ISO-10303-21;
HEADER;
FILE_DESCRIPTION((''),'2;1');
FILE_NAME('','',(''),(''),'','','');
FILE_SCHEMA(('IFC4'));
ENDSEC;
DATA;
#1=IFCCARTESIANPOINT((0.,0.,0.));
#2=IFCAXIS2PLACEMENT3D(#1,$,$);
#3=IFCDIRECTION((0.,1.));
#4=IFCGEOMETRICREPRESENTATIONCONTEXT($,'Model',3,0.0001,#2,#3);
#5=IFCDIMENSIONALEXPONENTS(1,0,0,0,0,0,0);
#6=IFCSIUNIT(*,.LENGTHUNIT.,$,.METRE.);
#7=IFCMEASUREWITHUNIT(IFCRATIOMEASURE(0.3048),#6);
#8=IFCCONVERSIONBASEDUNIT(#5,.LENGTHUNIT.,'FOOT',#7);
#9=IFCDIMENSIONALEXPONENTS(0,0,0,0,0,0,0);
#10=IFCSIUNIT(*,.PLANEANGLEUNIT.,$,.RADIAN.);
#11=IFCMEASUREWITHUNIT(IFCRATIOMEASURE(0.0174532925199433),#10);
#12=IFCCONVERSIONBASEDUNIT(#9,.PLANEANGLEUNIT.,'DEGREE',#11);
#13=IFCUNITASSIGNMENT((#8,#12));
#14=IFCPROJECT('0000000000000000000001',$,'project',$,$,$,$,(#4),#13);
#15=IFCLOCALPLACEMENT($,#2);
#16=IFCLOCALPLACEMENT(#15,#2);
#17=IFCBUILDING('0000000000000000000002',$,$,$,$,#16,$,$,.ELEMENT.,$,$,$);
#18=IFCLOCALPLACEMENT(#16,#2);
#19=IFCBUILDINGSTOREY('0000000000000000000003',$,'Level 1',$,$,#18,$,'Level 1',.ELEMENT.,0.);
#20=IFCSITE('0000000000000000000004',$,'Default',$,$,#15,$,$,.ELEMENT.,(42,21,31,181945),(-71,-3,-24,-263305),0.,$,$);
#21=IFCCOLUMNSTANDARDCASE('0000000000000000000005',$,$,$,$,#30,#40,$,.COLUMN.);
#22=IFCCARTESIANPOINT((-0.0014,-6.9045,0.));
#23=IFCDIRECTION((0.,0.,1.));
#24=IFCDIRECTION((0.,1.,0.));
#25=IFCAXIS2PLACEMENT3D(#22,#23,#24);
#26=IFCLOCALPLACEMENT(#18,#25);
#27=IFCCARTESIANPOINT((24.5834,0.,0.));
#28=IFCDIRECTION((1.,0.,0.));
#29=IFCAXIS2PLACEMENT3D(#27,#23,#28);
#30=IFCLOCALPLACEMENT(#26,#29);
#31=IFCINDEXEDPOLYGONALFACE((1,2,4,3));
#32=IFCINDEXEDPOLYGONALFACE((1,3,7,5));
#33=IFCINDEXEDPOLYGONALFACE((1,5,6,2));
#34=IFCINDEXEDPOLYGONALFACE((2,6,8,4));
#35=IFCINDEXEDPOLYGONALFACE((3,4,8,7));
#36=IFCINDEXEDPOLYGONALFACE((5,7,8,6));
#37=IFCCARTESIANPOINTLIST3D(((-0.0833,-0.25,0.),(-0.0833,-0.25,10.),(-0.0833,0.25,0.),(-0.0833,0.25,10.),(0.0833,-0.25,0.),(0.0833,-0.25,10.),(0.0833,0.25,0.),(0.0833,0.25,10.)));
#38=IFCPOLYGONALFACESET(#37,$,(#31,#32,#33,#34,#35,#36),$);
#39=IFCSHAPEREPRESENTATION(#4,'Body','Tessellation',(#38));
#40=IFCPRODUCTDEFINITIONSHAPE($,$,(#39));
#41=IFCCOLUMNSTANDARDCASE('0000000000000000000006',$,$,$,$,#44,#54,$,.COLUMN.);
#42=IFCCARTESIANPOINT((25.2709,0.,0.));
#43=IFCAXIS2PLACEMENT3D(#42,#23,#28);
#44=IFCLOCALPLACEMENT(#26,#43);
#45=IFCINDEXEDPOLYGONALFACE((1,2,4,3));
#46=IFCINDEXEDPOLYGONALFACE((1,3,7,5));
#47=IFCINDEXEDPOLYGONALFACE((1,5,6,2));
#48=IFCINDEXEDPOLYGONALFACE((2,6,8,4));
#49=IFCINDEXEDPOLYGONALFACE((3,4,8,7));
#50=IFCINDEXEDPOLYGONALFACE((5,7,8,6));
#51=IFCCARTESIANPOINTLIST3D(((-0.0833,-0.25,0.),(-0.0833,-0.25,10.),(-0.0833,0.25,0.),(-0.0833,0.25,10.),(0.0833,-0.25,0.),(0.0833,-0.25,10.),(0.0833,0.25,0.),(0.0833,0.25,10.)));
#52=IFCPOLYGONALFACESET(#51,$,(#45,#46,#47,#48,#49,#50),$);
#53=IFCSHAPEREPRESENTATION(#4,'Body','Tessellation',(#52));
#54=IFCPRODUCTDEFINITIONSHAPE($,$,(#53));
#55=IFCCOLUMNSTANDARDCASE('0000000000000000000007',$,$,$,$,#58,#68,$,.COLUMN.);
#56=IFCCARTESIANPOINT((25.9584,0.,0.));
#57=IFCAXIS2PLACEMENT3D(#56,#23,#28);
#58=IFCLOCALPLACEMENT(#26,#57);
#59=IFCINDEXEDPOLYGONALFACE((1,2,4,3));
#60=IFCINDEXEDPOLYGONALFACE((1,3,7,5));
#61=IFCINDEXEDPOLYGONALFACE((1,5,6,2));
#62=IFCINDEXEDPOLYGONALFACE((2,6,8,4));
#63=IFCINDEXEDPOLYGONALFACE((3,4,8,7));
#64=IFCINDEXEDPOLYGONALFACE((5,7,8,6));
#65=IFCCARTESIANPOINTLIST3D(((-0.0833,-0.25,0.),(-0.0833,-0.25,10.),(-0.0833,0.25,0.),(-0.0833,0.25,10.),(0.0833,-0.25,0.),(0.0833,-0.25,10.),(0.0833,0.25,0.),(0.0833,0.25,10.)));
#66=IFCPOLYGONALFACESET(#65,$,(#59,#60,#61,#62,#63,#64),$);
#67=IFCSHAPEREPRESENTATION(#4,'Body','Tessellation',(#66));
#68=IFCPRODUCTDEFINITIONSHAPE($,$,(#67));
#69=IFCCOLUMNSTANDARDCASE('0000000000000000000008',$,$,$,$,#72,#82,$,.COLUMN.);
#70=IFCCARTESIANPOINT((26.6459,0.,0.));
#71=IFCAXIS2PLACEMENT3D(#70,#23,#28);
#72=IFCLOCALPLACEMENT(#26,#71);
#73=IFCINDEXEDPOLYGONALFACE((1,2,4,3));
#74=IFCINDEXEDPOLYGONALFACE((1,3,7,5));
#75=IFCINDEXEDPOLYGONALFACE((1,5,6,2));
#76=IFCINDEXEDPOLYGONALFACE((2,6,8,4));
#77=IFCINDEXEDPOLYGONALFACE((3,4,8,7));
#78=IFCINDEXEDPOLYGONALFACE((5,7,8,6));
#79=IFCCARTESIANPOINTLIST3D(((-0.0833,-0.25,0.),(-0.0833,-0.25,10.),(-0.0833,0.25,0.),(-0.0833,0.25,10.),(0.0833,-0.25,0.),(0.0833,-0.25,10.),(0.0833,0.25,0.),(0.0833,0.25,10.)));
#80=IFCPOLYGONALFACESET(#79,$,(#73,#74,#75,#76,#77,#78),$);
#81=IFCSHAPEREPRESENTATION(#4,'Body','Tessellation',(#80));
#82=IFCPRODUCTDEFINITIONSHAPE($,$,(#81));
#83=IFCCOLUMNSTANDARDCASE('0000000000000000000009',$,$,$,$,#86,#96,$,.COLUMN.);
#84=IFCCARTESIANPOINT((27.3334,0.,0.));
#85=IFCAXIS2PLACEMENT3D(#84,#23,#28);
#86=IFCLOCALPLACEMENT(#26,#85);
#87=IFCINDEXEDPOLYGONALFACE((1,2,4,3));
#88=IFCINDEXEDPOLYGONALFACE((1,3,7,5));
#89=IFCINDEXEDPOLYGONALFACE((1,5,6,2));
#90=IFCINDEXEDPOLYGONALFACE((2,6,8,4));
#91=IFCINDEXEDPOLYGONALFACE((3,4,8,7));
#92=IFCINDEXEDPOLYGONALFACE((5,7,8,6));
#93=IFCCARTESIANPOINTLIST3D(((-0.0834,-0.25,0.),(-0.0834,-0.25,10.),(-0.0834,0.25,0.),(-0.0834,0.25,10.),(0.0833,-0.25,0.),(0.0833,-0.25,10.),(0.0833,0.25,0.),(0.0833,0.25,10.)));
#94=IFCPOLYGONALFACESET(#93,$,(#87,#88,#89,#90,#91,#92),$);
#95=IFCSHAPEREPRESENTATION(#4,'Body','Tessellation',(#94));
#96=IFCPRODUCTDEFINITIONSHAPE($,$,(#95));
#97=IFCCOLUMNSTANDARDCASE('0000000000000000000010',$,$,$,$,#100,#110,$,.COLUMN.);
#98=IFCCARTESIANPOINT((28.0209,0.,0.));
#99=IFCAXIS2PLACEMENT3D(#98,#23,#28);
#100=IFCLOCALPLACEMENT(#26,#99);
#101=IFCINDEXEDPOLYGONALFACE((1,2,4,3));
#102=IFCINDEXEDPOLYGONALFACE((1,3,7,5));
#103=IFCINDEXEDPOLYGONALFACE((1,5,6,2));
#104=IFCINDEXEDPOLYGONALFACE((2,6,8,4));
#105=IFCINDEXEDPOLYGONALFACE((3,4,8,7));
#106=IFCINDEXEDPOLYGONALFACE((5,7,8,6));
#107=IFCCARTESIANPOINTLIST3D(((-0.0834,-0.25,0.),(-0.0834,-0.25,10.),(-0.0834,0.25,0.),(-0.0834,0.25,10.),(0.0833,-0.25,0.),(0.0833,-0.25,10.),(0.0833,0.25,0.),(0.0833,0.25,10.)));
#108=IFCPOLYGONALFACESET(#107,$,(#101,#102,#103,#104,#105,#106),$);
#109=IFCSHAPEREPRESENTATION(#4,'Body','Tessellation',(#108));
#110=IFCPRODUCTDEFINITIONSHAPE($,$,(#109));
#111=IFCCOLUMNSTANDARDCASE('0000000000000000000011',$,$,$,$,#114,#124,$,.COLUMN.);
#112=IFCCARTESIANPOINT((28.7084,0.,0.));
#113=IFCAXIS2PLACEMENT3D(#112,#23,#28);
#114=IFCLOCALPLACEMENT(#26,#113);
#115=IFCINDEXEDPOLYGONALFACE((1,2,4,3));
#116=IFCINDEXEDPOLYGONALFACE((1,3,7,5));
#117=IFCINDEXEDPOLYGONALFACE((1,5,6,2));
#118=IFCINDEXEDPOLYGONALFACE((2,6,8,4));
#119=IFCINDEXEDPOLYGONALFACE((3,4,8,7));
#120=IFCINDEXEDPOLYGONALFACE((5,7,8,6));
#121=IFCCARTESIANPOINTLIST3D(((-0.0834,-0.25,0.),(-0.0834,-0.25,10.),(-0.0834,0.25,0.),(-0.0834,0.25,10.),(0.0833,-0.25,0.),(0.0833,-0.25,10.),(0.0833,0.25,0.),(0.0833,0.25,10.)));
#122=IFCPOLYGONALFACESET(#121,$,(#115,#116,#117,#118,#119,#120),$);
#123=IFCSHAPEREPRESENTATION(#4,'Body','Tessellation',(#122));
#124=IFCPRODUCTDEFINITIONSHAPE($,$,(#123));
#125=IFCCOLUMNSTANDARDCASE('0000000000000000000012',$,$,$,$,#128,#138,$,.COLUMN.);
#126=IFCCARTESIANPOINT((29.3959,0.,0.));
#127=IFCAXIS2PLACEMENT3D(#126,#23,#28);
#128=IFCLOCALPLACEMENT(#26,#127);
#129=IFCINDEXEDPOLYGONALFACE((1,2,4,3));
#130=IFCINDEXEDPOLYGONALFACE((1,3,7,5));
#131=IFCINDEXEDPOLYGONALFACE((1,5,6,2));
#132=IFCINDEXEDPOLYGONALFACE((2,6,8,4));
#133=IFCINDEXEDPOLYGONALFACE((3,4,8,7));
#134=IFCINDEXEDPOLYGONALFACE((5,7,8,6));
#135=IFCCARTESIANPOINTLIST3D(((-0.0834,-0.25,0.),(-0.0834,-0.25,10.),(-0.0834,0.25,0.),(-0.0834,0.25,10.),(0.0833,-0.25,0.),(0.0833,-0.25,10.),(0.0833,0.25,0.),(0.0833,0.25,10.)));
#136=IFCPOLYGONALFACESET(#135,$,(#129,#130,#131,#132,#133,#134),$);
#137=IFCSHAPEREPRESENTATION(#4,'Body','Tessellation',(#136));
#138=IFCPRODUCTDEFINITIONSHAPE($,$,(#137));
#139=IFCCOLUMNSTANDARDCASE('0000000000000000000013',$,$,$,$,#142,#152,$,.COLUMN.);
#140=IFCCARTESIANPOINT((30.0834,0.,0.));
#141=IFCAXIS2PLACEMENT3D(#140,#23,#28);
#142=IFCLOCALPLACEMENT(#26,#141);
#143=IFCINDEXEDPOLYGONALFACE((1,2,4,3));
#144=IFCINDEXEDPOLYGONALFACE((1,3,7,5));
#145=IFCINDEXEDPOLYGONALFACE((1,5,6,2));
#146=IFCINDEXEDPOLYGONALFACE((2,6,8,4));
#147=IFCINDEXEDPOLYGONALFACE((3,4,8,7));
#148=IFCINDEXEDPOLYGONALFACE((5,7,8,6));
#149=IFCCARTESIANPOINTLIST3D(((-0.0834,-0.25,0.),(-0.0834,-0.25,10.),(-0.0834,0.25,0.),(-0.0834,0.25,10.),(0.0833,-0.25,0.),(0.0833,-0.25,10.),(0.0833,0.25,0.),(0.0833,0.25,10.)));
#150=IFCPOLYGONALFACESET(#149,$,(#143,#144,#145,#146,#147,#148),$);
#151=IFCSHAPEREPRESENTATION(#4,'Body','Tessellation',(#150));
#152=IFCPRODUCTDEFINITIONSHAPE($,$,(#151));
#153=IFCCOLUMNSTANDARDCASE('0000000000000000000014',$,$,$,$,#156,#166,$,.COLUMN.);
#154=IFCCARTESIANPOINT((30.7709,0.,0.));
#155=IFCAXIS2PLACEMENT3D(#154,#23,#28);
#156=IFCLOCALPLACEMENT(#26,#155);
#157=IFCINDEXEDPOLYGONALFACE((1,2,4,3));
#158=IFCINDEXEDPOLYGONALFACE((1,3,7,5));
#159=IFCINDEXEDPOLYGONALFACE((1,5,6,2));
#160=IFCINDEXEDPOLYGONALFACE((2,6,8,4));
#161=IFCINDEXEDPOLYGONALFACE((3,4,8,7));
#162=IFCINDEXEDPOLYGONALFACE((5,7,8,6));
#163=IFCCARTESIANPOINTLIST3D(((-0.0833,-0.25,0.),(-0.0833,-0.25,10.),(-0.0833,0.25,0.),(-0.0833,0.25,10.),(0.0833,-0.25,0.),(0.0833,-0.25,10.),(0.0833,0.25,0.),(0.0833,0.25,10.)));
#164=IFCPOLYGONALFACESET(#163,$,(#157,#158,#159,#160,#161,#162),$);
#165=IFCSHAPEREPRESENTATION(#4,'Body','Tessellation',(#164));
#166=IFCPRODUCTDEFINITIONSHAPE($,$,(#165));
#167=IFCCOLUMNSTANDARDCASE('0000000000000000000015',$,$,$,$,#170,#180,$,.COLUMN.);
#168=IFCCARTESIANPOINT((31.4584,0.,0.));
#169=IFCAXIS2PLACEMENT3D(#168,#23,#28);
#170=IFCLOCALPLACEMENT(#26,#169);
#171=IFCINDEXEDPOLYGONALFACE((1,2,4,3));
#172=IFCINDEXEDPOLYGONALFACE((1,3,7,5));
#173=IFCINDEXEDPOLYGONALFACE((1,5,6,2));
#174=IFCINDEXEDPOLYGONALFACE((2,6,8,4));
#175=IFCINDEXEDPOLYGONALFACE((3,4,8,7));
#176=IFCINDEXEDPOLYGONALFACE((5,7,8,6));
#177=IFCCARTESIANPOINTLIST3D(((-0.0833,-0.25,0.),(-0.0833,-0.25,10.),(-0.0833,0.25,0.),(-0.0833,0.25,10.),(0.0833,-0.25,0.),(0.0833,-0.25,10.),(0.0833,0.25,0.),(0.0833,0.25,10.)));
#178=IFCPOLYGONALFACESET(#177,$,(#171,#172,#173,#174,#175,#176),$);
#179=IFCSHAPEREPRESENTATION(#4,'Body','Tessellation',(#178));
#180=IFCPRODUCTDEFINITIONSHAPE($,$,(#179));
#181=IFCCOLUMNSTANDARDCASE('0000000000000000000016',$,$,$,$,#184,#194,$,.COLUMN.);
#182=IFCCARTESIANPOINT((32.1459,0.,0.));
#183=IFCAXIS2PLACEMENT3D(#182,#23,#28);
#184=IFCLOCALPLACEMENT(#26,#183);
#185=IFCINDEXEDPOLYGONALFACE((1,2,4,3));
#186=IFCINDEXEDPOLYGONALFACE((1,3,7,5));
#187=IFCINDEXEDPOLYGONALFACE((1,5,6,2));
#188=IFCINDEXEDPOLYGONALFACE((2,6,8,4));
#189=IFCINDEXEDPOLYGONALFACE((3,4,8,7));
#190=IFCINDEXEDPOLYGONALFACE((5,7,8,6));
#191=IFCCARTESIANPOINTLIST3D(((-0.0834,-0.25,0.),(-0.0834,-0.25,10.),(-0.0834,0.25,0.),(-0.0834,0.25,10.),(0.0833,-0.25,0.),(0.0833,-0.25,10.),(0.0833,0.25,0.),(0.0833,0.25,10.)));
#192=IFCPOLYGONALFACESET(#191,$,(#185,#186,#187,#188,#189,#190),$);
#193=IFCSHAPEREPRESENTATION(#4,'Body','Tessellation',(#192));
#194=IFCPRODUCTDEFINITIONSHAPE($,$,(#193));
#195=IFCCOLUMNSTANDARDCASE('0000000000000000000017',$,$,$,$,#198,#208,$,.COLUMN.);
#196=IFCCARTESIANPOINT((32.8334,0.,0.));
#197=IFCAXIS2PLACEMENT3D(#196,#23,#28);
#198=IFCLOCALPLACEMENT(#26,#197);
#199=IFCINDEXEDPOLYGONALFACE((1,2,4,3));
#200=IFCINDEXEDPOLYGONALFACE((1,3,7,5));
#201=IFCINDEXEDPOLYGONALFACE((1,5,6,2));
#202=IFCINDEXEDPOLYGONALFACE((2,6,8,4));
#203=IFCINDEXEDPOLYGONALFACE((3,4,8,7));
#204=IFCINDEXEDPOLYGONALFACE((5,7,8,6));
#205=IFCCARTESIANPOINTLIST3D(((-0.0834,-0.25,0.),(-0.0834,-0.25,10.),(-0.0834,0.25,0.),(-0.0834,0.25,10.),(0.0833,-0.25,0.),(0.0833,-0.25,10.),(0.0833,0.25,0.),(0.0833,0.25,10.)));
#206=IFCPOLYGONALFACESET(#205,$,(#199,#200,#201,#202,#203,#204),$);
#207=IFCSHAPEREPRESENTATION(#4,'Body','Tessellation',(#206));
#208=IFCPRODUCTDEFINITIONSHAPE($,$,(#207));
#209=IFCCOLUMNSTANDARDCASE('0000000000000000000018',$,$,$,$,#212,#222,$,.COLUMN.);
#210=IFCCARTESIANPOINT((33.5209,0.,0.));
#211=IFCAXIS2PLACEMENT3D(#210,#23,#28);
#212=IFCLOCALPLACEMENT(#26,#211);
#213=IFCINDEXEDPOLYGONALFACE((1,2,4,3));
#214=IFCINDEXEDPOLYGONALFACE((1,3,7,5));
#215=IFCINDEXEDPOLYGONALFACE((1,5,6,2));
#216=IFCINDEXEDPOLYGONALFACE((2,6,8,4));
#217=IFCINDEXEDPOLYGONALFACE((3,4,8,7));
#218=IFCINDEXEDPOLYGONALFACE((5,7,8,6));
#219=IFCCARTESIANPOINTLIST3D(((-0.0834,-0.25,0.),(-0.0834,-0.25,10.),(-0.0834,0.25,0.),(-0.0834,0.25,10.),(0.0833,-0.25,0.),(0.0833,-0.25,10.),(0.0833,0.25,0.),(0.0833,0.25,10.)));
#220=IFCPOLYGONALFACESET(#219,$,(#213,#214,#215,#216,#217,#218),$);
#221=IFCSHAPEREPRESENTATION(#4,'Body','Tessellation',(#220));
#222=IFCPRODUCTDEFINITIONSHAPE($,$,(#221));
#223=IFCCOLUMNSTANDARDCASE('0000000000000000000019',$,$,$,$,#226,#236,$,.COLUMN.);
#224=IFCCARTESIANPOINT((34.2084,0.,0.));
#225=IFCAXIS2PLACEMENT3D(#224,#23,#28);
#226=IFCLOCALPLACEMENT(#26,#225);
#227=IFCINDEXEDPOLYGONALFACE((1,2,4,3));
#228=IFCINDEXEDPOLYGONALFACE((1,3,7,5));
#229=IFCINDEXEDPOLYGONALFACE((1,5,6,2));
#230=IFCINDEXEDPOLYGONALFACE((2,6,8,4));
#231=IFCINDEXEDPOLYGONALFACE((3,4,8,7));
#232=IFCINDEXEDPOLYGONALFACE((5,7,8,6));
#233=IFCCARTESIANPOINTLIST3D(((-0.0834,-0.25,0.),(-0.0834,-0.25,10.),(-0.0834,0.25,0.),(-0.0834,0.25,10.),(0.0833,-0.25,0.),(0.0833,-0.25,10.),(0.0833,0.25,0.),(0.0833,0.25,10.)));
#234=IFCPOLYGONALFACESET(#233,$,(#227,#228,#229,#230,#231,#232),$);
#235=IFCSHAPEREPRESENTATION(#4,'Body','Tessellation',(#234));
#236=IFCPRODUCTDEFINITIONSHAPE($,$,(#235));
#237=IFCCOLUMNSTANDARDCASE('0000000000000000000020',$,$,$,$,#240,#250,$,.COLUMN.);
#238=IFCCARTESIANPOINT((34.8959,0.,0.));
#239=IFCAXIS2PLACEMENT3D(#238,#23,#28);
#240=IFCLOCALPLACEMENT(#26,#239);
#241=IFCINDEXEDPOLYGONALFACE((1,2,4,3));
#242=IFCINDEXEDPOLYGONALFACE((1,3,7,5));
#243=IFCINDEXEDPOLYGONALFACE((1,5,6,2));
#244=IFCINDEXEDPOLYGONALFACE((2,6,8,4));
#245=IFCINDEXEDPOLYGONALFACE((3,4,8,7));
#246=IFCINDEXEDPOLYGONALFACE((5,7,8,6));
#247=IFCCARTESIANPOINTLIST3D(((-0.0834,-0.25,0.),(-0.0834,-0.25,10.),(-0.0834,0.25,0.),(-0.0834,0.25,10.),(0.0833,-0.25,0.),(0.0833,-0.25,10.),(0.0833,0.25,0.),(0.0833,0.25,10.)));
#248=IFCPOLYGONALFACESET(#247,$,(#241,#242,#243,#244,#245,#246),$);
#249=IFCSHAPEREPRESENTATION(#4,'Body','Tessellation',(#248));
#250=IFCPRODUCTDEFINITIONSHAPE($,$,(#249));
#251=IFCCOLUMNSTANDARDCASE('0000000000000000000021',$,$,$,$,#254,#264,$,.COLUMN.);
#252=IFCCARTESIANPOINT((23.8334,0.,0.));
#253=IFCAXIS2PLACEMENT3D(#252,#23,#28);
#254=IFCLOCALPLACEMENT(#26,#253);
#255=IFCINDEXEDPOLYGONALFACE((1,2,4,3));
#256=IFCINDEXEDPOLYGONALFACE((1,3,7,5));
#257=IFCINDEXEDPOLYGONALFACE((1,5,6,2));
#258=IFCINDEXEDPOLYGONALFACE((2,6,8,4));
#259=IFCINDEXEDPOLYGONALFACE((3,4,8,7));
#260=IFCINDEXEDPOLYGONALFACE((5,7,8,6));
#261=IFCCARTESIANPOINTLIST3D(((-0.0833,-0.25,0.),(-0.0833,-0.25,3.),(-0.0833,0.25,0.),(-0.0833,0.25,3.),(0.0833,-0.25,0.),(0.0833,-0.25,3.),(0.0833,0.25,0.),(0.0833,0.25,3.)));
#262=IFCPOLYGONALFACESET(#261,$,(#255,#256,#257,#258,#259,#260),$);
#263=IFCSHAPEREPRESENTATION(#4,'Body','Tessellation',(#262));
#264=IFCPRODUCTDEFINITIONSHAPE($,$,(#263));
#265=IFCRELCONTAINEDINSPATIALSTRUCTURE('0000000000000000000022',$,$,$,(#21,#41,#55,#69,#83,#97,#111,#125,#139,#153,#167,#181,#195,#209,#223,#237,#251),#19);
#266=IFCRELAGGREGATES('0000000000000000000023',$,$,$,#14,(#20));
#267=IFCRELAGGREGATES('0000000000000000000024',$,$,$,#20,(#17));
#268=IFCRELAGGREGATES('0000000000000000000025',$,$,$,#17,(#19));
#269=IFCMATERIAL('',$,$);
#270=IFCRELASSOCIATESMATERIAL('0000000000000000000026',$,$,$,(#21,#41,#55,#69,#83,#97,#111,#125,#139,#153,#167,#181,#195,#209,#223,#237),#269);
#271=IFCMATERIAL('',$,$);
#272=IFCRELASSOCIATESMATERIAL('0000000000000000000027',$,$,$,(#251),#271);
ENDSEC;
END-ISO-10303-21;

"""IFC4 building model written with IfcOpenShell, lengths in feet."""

from ifc_helpers import new_model, entity, si_unit, converted_unit, direction, frame, origin, place, context, project, spatial, rectangle, extrude, material, element, save


model = new_model("IFC4")

# Units and contexts
model_context = context("Model", 3, precision=0.0001, world=origin(), true_north=direction((0.0, 1.0)))
ifc_project = project(units=[converted_unit("LENGTHUNIT", "FOOT", entity("IfcRatioMeasure", 0.3048), si_unit("LENGTHUNIT", "METRE"), dimensions=[1, 0, 0, 0, 0, 0, 0]), converted_unit("PLANEANGLEUNIT", "DEGREE", entity("IfcRatioMeasure", 0.0174532925199433), si_unit("PLANEANGLEUNIT", "RADIAN"), dimensions=[0, 0, 0, 0, 0, 0, 0])], contexts=[model_context])

# Site, building, storey
site_placement = place(None, origin())
site = spatial("IfcSite", under=ifc_project, at=site_placement, Name="Default", CompositionType="ELEMENT", RefLatitude=(42, 21, 31, 181945), RefLongitude=(-71, -3, -24, -263305), RefElevation=0.0)
building_placement = place(site_placement, origin())
building = spatial("IfcBuilding", under=site, at=building_placement, CompositionType="ELEMENT")
storey_placement = place(building_placement, origin())
storey = spatial("IfcBuildingStorey", under=building, at=storey_placement, Name="Level 1", LongName="Level 1", CompositionType="ELEMENT", Elevation=0.0)

# Columns
ifc_material_1 = material(Name="")
placement_1 = place(storey_placement, frame((-0.0014, -6.9045, 0.0), z_axis=(0.0, 0.0, 1.0), x_axis=(0.0, 1.0, 0.0)))
for number, where, z_axis, x_axis in (
    (1, (24.5834, 0.0, 0.0), (0.0, 0.0, 1.0), (1.0, 0.0, 0.0)),
    (2, (25.2709, 0.0, 0.0), (0.0, 0.0, 1.0), (1.0, 0.0, 0.0)),
    (3, (25.9584, 0.0, 0.0), (0.0, 0.0, 1.0), (1.0, 0.0, 0.0)),
    (4, (26.6459, 0.0, 0.0), (0.0, 0.0, 1.0), (1.0, 0.0, 0.0)),
    (5, (27.3334, 0.0, 0.0), (0.0, 0.0, 1.0), (1.0, 0.0, 0.0)),
    (6, (28.0209, 0.0, 0.0), (0.0, 0.0, 1.0), (1.0, 0.0, 0.0)),
    (7, (28.7084, 0.0, 0.0), (0.0, 0.0, 1.0), (1.0, 0.0, 0.0)),
    (8, (29.3959, 0.0, 0.0), (0.0, 0.0, 1.0), (1.0, 0.0, 0.0)),
    (9, (30.0834, 0.0, 0.0), (0.0, 0.0, 1.0), (1.0, 0.0, 0.0)),
    (10, (30.7709, 0.0, 0.0), (0.0, 0.0, 1.0), (1.0, 0.0, 0.0)),
    (11, (31.4584, 0.0, 0.0), (0.0, 0.0, 1.0), (1.0, 0.0, 0.0)),
    (12, (32.1459, 0.0, 0.0), (0.0, 0.0, 1.0), (1.0, 0.0, 0.0)),
    (13, (32.8334, 0.0, 0.0), (0.0, 0.0, 1.0), (1.0, 0.0, 0.0)),
    (14, (33.5209, 0.0, 0.0), (0.0, 0.0, 1.0), (1.0, 0.0, 0.0)),
    (15, (34.2084, 0.0, 0.0), (0.0, 0.0, 1.0), (1.0, 0.0, 0.0)),
    (16, (34.8959, 0.0, 0.0), (0.0, 0.0, 1.0), (1.0, 0.0, 0.0)),
):
    element("IfcColumnStandardCase", number, at=place(placement_1, frame(where, z_axis=z_axis, x_axis=x_axis)), inside=storey, material=ifc_material_1, PredefinedType="COLUMN", context=model_context, shape_type="SweptSolid", body=[
        extrude(rectangle(XDim=0.1667, YDim=0.5), origin(), (0.0, 0.0, 1.0), 10.0),
    ])
ifc_material_2 = material(Name="")
for number, where, z_axis, x_axis in (
    (17, (23.8334, 0.0, 0.0), (0.0, 0.0, 1.0), (1.0, 0.0, 0.0)),
):
    element("IfcColumnStandardCase", number, at=place(placement_1, frame(where, z_axis=z_axis, x_axis=x_axis)), inside=storey, material=ifc_material_2, PredefinedType="COLUMN", context=model_context, shape_type="SweptSolid", body=[
        extrude(rectangle(XDim=0.1667, YDim=0.5), origin(), (0.0, 0.0, 1.0), 3.0),
    ])

save(model, "model.ifc")
